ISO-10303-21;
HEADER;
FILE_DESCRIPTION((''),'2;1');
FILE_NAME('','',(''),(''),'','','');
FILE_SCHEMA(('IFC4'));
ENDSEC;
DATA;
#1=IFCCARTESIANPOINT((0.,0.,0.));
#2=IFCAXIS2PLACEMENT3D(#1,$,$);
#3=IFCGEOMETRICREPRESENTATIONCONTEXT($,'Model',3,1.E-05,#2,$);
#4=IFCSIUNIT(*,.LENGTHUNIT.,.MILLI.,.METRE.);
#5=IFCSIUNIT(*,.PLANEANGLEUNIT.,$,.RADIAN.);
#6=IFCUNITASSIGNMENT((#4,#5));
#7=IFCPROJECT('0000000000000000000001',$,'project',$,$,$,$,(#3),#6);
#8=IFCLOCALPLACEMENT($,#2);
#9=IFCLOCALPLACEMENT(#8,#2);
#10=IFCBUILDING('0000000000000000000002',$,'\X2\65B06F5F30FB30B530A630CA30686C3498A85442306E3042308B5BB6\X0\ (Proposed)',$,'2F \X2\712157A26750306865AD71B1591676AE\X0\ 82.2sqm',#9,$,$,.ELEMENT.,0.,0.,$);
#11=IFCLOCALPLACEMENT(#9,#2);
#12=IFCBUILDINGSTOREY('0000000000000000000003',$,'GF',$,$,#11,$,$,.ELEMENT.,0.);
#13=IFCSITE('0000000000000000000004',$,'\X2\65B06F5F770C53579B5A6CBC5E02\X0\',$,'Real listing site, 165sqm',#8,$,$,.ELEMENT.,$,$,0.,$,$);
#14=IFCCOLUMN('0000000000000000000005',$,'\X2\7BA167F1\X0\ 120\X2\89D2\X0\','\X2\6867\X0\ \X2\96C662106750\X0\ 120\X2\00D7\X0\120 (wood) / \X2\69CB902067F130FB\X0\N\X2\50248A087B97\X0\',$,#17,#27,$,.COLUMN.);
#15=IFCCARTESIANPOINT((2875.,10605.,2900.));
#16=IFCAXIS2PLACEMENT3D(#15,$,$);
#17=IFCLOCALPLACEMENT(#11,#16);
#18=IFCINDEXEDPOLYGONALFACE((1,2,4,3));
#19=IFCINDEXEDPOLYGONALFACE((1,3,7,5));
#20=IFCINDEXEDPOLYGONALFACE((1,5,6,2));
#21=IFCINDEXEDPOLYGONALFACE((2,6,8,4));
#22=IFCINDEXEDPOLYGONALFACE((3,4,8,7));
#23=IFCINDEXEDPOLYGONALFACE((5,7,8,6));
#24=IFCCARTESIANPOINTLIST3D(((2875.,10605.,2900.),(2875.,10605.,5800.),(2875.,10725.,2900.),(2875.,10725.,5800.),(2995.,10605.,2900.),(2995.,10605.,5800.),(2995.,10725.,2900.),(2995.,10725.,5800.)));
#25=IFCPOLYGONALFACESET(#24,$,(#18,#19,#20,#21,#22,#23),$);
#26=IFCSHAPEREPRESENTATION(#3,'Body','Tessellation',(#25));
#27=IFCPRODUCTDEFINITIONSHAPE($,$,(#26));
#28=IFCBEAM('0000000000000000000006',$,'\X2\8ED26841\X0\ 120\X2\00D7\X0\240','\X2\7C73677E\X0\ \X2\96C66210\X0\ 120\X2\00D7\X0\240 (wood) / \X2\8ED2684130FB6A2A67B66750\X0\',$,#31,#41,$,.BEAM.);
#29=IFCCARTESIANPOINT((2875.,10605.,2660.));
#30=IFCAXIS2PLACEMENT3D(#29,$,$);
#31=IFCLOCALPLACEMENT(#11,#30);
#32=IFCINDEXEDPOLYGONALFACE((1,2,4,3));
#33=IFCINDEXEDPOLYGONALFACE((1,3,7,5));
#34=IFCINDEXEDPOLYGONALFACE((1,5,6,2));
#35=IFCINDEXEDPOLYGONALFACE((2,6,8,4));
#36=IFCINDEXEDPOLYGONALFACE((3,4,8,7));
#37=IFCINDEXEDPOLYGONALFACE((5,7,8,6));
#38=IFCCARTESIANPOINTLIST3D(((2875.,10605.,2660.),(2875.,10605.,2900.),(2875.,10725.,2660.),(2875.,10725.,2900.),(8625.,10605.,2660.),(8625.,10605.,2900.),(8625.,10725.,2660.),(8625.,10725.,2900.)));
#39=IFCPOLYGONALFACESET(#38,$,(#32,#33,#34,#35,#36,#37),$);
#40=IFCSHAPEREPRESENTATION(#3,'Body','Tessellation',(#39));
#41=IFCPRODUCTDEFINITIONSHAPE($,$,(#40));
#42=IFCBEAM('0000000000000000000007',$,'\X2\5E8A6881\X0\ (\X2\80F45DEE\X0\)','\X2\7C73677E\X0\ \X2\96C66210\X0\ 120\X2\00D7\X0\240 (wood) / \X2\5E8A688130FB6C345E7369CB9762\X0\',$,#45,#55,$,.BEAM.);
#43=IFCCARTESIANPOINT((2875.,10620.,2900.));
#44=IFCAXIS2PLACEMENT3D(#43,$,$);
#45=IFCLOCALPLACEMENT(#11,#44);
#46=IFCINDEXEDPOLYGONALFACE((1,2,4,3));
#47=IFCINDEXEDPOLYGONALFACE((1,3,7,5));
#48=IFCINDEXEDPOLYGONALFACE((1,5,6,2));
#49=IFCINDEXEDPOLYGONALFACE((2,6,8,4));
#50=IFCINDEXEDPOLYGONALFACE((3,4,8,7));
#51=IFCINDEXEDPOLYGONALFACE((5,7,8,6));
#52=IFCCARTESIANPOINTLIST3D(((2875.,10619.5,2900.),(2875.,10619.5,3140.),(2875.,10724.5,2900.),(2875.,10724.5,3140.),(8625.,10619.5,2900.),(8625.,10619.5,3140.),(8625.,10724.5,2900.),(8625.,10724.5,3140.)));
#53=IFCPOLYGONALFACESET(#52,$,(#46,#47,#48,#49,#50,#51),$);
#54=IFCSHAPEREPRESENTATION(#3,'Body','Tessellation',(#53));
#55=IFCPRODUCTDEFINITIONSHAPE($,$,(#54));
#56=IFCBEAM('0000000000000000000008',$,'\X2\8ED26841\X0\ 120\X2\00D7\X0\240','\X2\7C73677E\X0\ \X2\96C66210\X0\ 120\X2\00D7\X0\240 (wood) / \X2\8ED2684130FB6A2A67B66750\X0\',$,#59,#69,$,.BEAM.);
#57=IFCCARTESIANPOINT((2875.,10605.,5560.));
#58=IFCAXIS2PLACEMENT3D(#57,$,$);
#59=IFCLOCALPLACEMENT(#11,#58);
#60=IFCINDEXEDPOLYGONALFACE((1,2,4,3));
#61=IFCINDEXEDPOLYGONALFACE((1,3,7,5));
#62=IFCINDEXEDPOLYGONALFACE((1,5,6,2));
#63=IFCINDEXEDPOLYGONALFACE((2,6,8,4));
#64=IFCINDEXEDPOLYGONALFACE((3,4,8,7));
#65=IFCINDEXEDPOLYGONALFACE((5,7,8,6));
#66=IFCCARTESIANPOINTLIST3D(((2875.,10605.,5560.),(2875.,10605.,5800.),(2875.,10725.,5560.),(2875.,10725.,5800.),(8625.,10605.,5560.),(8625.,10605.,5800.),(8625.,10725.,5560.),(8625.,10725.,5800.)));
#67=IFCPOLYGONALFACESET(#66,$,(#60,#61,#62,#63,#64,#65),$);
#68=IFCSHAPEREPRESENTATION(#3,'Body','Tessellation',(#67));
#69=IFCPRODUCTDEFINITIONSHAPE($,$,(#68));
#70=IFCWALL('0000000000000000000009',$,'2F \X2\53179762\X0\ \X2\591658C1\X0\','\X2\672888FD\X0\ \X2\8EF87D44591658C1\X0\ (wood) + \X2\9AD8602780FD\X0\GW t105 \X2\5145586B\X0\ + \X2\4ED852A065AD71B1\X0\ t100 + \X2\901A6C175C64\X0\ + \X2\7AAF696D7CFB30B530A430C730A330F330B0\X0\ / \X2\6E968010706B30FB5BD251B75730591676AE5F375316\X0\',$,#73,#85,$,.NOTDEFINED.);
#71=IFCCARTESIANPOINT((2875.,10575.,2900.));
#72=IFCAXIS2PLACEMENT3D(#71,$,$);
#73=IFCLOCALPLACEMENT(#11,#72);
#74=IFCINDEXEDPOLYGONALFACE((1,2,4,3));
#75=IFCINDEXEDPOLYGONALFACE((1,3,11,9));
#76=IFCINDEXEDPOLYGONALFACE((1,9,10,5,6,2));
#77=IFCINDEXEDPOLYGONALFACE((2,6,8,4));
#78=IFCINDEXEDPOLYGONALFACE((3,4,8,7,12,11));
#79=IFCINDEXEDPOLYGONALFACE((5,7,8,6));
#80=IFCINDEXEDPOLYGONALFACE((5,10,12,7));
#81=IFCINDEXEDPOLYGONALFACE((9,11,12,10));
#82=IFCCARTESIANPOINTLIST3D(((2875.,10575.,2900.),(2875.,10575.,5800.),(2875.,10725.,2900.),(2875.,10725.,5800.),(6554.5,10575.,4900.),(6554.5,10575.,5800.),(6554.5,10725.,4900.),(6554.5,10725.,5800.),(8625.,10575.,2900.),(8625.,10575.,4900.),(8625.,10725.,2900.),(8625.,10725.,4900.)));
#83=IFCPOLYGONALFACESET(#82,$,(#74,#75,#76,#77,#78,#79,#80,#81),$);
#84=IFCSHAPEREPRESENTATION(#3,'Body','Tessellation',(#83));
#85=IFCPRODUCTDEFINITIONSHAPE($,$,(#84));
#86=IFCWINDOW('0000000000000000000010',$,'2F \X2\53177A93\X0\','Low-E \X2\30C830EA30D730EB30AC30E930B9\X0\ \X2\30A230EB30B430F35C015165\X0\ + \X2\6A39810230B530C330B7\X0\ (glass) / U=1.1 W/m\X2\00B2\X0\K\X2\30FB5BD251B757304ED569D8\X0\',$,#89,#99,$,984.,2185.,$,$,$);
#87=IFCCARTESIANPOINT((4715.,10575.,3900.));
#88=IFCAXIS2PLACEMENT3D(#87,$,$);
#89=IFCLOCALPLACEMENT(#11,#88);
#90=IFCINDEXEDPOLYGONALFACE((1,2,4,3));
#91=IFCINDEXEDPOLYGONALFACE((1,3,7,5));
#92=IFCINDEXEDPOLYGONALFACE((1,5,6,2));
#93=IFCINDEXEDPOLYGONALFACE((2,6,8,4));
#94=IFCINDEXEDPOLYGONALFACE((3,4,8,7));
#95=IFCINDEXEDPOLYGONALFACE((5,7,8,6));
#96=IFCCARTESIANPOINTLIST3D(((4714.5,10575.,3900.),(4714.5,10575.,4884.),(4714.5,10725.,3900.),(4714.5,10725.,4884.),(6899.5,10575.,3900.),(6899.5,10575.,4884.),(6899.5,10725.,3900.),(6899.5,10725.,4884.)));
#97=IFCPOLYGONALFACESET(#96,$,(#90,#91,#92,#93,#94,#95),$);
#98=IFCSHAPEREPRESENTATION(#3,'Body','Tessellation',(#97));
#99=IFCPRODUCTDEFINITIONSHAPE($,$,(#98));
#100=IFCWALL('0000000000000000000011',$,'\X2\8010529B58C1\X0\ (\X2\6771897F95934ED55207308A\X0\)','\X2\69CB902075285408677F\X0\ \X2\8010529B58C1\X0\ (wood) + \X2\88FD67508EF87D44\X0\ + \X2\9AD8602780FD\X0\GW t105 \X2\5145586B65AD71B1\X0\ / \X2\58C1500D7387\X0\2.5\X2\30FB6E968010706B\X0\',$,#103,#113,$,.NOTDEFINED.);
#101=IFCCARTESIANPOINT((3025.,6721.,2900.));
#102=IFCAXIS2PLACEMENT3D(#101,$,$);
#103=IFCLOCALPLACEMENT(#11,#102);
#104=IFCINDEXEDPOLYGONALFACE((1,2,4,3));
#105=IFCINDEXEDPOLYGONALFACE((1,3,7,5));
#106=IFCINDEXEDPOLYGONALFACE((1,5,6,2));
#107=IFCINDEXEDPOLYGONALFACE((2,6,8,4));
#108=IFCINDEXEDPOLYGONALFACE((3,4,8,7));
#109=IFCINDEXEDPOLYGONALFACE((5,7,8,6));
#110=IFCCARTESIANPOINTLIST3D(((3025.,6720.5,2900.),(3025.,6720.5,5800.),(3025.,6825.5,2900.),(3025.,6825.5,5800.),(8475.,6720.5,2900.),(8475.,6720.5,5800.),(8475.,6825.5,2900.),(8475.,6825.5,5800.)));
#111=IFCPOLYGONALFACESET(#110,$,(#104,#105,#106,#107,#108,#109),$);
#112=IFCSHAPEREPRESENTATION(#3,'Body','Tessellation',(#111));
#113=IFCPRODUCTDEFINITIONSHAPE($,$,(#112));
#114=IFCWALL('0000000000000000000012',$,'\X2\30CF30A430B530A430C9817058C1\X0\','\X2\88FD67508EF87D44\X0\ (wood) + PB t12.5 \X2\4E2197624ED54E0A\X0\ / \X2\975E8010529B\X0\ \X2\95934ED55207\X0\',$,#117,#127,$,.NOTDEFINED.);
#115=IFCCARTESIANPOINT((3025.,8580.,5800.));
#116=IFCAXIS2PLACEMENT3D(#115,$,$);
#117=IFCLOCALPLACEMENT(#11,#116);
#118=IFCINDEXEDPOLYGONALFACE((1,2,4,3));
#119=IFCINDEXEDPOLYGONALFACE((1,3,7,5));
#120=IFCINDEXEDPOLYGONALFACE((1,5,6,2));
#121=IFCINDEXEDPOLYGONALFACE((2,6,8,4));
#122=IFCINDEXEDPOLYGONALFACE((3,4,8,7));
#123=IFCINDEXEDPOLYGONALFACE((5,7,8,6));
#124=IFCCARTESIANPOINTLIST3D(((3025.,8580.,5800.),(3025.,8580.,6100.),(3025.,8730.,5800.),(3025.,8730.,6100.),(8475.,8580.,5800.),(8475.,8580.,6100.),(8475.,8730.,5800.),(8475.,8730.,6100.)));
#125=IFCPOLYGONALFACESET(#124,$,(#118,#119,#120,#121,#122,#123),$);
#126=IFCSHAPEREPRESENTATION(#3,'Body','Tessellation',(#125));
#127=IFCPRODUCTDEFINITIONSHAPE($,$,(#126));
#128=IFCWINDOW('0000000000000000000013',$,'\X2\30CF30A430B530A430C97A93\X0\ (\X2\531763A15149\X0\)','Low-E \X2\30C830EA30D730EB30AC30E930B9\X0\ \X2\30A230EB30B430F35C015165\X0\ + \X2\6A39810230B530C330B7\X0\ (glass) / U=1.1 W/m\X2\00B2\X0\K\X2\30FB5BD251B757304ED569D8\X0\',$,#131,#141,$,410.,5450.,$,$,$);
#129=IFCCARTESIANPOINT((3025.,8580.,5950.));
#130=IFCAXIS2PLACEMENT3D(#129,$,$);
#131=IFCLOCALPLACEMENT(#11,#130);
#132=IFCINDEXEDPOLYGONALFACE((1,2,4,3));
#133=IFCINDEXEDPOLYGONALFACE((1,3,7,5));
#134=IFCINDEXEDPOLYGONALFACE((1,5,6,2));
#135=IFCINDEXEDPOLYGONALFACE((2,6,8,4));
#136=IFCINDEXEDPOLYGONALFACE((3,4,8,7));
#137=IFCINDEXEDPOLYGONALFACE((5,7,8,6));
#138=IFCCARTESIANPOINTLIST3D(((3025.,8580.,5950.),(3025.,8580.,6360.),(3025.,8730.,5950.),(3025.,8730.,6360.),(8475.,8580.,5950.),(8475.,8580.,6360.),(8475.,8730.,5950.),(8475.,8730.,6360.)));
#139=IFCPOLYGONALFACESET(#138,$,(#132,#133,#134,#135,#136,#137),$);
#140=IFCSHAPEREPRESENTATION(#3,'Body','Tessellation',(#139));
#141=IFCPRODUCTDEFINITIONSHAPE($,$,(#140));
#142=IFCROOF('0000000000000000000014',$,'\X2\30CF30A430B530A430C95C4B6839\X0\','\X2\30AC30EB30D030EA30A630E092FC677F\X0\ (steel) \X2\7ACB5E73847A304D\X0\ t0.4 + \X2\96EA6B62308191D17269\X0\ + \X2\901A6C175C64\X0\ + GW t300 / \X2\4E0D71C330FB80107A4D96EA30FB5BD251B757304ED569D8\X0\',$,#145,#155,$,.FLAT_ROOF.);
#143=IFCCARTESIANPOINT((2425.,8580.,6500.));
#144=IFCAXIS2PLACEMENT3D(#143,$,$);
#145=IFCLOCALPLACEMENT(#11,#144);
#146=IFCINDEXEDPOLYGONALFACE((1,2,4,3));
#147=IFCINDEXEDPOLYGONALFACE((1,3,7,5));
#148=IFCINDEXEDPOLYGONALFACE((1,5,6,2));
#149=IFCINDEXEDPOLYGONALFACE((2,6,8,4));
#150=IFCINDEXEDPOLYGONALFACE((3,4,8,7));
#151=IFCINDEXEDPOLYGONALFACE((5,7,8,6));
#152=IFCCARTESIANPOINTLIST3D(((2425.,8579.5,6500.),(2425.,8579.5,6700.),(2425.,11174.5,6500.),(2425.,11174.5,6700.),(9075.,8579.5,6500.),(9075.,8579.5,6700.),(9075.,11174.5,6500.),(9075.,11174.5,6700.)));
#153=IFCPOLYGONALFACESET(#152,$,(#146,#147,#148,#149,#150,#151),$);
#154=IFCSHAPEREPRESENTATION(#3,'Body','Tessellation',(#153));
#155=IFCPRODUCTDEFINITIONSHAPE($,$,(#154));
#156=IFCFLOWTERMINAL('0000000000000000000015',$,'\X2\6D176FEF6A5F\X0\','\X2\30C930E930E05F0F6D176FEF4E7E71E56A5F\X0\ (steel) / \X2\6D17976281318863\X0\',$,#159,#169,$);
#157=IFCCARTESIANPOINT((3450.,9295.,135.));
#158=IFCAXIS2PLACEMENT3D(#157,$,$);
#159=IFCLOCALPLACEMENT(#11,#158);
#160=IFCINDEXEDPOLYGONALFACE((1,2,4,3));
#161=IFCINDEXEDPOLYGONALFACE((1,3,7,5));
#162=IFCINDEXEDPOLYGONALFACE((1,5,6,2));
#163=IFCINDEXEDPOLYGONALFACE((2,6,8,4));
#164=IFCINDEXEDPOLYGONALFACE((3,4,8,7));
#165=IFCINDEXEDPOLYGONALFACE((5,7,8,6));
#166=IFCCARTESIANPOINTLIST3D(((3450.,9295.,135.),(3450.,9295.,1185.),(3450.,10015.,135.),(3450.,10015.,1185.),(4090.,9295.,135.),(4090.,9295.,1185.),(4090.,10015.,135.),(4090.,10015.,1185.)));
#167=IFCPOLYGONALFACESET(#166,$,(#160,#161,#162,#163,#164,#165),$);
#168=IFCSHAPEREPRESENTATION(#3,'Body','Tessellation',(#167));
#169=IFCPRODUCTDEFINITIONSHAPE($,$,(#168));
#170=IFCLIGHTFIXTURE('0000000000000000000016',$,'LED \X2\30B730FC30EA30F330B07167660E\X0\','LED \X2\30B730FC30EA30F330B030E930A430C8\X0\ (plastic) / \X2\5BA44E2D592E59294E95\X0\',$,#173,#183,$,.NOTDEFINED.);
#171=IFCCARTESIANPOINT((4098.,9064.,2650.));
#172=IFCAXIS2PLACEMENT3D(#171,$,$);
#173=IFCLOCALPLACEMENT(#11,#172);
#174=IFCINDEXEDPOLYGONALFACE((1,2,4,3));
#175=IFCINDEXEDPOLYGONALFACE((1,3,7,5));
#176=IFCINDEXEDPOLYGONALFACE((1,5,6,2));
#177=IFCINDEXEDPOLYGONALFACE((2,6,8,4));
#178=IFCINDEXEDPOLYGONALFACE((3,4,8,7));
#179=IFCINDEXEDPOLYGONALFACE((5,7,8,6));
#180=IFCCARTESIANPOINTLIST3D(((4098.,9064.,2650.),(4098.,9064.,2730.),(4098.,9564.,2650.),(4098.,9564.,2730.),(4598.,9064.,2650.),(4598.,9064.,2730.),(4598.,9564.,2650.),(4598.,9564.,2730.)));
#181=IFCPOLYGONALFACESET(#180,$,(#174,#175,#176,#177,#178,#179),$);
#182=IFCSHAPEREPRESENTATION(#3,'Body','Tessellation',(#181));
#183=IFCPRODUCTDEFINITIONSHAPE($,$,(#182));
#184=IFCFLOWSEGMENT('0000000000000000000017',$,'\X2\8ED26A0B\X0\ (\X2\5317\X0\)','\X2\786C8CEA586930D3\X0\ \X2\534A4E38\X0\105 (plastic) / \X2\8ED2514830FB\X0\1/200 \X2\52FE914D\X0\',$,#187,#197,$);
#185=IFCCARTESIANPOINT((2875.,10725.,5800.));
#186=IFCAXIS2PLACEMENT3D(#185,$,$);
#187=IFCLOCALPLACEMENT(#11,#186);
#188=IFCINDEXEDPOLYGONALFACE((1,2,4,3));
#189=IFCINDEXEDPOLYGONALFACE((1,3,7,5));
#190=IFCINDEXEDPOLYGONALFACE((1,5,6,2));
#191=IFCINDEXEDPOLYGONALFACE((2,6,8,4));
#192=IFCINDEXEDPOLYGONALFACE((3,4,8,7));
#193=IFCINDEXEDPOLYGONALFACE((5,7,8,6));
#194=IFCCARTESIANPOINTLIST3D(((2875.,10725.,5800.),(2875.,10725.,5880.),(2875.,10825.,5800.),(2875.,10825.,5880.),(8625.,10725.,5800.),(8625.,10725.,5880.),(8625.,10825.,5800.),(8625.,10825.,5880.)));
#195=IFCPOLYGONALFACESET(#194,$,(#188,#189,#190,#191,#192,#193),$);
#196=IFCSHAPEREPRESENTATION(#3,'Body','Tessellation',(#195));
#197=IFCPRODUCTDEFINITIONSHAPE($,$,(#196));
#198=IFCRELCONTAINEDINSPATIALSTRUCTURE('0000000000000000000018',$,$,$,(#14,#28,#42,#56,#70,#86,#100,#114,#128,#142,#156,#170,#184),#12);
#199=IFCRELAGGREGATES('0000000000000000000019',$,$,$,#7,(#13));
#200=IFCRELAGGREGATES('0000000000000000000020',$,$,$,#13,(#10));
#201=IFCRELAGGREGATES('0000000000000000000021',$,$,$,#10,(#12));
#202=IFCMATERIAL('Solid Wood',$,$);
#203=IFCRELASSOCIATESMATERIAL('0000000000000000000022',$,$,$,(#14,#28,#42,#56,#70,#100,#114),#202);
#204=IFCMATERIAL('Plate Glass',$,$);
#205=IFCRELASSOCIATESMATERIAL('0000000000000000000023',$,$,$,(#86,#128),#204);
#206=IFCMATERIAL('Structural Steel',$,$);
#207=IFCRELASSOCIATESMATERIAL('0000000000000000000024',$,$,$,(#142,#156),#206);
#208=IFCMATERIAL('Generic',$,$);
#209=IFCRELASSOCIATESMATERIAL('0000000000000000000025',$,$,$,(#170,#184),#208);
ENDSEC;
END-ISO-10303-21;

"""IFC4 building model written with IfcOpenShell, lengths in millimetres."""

from ifc_helpers import new_model, si_unit, frame, frame_2d, origin, place, context, project, spatial, rectangle, extrude, material, element, fill, save


model = new_model("IFC4")

# Units and contexts
model_context = context("Model", 3, precision=1e-05, world=origin())
ifc_project = project(units=[si_unit("LENGTHUNIT", "METRE", prefix="MILLI"), si_unit("PLANEANGLEUNIT", "RADIAN")], contexts=[model_context])

# Site, building, storey
site_placement = place(None, origin())
site = spatial("IfcSite", under=ifc_project, at=site_placement, Name="新潟県南魚沼市", ObjectType="Real listing site, 165sqm", CompositionType="ELEMENT", RefElevation=0.0)
building_placement = place(site_placement, origin())
building = spatial("IfcBuilding", under=site, at=building_placement, Name="新潟・サウナと水風呂のある家 (Proposed)", ObjectType="2F 無垢材と断熱外皮 82.2sqm", CompositionType="ELEMENT", ElevationOfRefHeight=0.0, ElevationOfTerrain=0.0)
storey_placement = place(building_placement, origin())
storey = spatial("IfcBuildingStorey", under=building, at=storey_placement, Name="GF", CompositionType="ELEMENT", Elevation=0.0)

# Column
ifc_material_1 = material(Name="Solid Wood")
column_1_placement = place(storey_placement, frame((2875.0, 10605.0, 2900.0)))
element("IfcColumn", 1, at=column_1_placement, inside=storey, material=ifc_material_1, Name="管柱 120角", Description="桧 集成材 120×120 (wood) / 構造柱・N値計算", PredefinedType="COLUMN", context=model_context, shape_type="SweptSolid", body=[
    extrude(rectangle(XDim=120.0, YDim=120.0, at=frame_2d((60.0, 60.0))), frame((2875.0, 10605.0, 2900.0)), (0.0, 0.0, 1.0), 2900.0),
])

# Beams
beam_1_placement = place(storey_placement, frame((2875.0, 10605.0, 2660.0)))
element("IfcBeam", 2, at=beam_1_placement, inside=storey, material=ifc_material_1, Name="軒桁 120×240", Description="米松 集成 120×240 (wood) / 軒桁・横架材", PredefinedType="BEAM", context=model_context, shape_type="SweptSolid", body=[
    extrude(rectangle(XDim=5750.0, YDim=120.0, at=frame_2d((2875.0, 60.0))), frame((2875.0, 10605.0, 2660.0)), (0.0, 0.0, 1.0), 240.0),
])
beam_2_placement = place(storey_placement, frame((2875.0, 10620.0, 2900.0)))
element("IfcBeam", 3, at=beam_2_placement, inside=storey, material=ifc_material_1, Name="床梁 (胴差)", Description="米松 集成 120×240 (wood) / 床梁・水平構面", PredefinedType="BEAM", context=model_context, shape_type="SweptSolid", body=[
    extrude(rectangle(XDim=5750.0, YDim=105.0, at=frame_2d((2875.0, 52.0))), frame((2875.0, 10620.0, 2900.0)), (0.0, 0.0, 1.0), 240.0),
])
beam_3_placement = place(storey_placement, frame((2875.0, 10605.0, 5560.0)))
element("IfcBeam", 4, at=beam_3_placement, inside=storey, material=ifc_material_1, Name="軒桁 120×240", Description="米松 集成 120×240 (wood) / 軒桁・横架材", PredefinedType="BEAM", context=model_context, shape_type="SweptSolid", body=[
    extrude(rectangle(XDim=5750.0, YDim=120.0, at=frame_2d((2875.0, 60.0))), frame((2875.0, 10605.0, 5560.0)), (0.0, 0.0, 1.0), 240.0),
])

# Wall, opening, window
wall_1_placement = place(storey_placement, frame((2875.0, 10575.0, 2900.0)))
wall_1 = element("IfcWall", 5, at=wall_1_placement, inside=storey, material=ifc_material_1, Name="2F 北面 外壁", Description="木製 軸組外壁 (wood) + 高性能GW t105 充填 + 付加断熱 t100 + 通気層 + 窯業系サイディング / 準耐火・寒冷地外皮強化", PredefinedType="NOTDEFINED", context=model_context, shape_type="SweptSolid", body=[
    extrude(rectangle(XDim=5750.0, YDim=150.0, at=frame_2d((2875.0, 75.0))), frame((2875.0, 10575.0, 2900.0)), (0.0, 0.0, 1.0), 2900.0),
])
opening_1_placement = place(storey_placement, frame((4715.0, 10575.0, 3900.0)))
opening_1 = element("IfcOpeningElement", 6, at=opening_1_placement, cuts=wall_1, PredefinedType="NOTDEFINED", context=model_context, shape_type="SweptSolid", body=[
    extrude(rectangle(XDim=2185.0, YDim=150.0, at=frame_2d((1092.0, 75.0))), frame((4715.0, 10575.0, 3900.0)), (0.0, 0.0, 1.0), 984.0),
])
ifc_material_2 = material(Name="Plate Glass")
window_1_placement = place(storey_placement, frame((4715.0, 10575.0, 3900.0)))
window_1 = element("IfcWindow", 7, at=window_1_placement, inside=storey, material=ifc_material_2, Name="2F 北窓", Description="Low-E トリプルガラス アルゴン封入 + 樹脂サッシ (glass) / U=1.1 W/m²K・寒冷地仕様", OverallHeight=984.0, OverallWidth=2185.0, context=model_context, shape_type="SweptSolid", body=[
    extrude(rectangle(XDim=2185.0, YDim=150.0, at=frame_2d((1092.0, 75.0))), frame((4715.0, 10575.0, 3900.0)), (0.0, 0.0, 1.0), 984.0),
])
fill(opening_1, window_1)

# Wall
wall_2_placement = place(storey_placement, frame((3025.0, 6721.0, 2900.0)))
element("IfcWall", 8, at=wall_2_placement, inside=storey, material=ifc_material_1, Name="耐力壁 (東西間仕切り)", Description="構造用合板 耐力壁 (wood) + 製材軸組 + 高性能GW t105 充填断熱 / 壁倍率2.5・準耐火", PredefinedType="NOTDEFINED", context=model_context, shape_type="SweptSolid", body=[
    extrude(rectangle(XDim=5450.0, YDim=105.0, at=frame_2d((2725.0, 52.0))), frame((3025.0, 6721.0, 2900.0)), (0.0, 0.0, 1.0), 2900.0),
])

# Wall, opening, window
wall_3_placement = place(storey_placement, frame((3025.0, 8580.0, 5800.0)))
wall_3 = element("IfcWall", 9, at=wall_3_placement, inside=storey, material=ifc_material_1, Name="ハイサイド腰壁", Description="製材軸組 (wood) + PB t12.5 両面仕上 / 非耐力 間仕切", PredefinedType="NOTDEFINED", context=model_context, shape_type="SweptSolid", body=[
    extrude(rectangle(XDim=5450.0, YDim=150.0, at=frame_2d((2725.0, 75.0))), frame((3025.0, 8580.0, 5800.0)), (0.0, 0.0, 1.0), 700.0),
])
opening_2_placement = place(storey_placement, frame((3025.0, 8580.0, 5950.0)))
opening_2 = element("IfcOpeningElement", 10, at=opening_2_placement, cuts=wall_3, PredefinedType="NOTDEFINED", context=model_context, shape_type="SweptSolid", body=[
    extrude(rectangle(XDim=5450.0, YDim=150.0, at=frame_2d((2725.0, 75.0))), frame((3025.0, 8580.0, 5950.0)), (0.0, 0.0, 1.0), 410.0),
])
window_2_placement = place(storey_placement, frame((3025.0, 8580.0, 5950.0)))
window_2 = element("IfcWindow", 11, at=window_2_placement, inside=storey, material=ifc_material_2, Name="ハイサイド窓 (北採光)", Description="Low-E トリプルガラス アルゴン封入 + 樹脂サッシ (glass) / U=1.1 W/m²K・寒冷地仕様", OverallHeight=410.0, OverallWidth=5450.0, context=model_context, shape_type="SweptSolid", body=[
    extrude(rectangle(XDim=5450.0, YDim=150.0, at=frame_2d((2725.0, 75.0))), frame((3025.0, 8580.0, 5950.0)), (0.0, 0.0, 1.0), 410.0),
])
fill(opening_2, window_2)

# Roof
ifc_material_3 = material(Name="Structural Steel")
roof_placement = place(storey_placement, frame((2425.0, 8580.0, 6500.0)))
element("IfcRoof", 12, at=roof_placement, inside=storey, material=ifc_material_3, Name="ハイサイド屋根", Description="ガルバリウム鋼板 (steel) 立平葺き t0.4 + 雪止め金物 + 通気層 + GW t300 / 不燃・耐積雪・寒冷地仕様", PredefinedType="FLAT_ROOF", context=model_context, shape_type="SweptSolid", body=[
    extrude(rectangle(XDim=6650.0, YDim=2595.0, at=frame_2d((3325.0, 1297.0))), frame((2425.0, 8580.0, 6500.0)), (0.0, 0.0, 1.0), 200.0),
])

# Flow terminal
flow_terminal_placement = place(storey_placement, frame((3450.0, 9295.0, 135.0)))
element("IfcFlowTerminal", 13, at=flow_terminal_placement, inside=storey, material=ifc_material_3, Name="洗濯機", Description="ドラム式洗濯乾燥機 (steel) / 洗面脱衣", context=model_context, shape_type="SweptSolid", body=[
    extrude(rectangle(XDim=640.0, YDim=720.0, at=frame_2d((320.0, 360.0))), frame((3450.0, 9295.0, 135.0)), (0.0, 0.0, 1.0), 1050.0),
])

# Light fixture
ifc_material_4 = material(Name="Generic")
light_fixture_placement = place(storey_placement, frame((4098.0, 9064.0, 2650.0)))
element("IfcLightFixture", 14, at=light_fixture_placement, inside=storey, material=ifc_material_4, Name="LED シーリング照明", Description="LED シーリングライト (plastic) / 室中央天井", PredefinedType="NOTDEFINED", context=model_context, shape_type="SweptSolid", body=[
    extrude(rectangle(XDim=500.0, YDim=500.0, at=frame_2d((250.0, 250.0))), frame((4098.0, 9064.0, 2650.0)), (0.0, 0.0, 1.0), 80.0),
])

# Flow segment
flow_segment_placement = place(storey_placement, frame((2875.0, 10725.0, 5800.0)))
element("IfcFlowSegment", 15, at=flow_segment_placement, inside=storey, material=ifc_material_4, Name="軒樋 (北)", Description="硬質塩ビ 半丸105 (plastic) / 軒先・1/200 勾配", context=model_context, shape_type="SweptSolid", body=[
    extrude(rectangle(XDim=5750.0, YDim=100.0, at=frame_2d((2875.0, 50.0))), frame((2875.0, 10725.0, 5800.0)), (0.0, 0.0, 1.0), 80.0),
])

save(model, "model.ifc")
